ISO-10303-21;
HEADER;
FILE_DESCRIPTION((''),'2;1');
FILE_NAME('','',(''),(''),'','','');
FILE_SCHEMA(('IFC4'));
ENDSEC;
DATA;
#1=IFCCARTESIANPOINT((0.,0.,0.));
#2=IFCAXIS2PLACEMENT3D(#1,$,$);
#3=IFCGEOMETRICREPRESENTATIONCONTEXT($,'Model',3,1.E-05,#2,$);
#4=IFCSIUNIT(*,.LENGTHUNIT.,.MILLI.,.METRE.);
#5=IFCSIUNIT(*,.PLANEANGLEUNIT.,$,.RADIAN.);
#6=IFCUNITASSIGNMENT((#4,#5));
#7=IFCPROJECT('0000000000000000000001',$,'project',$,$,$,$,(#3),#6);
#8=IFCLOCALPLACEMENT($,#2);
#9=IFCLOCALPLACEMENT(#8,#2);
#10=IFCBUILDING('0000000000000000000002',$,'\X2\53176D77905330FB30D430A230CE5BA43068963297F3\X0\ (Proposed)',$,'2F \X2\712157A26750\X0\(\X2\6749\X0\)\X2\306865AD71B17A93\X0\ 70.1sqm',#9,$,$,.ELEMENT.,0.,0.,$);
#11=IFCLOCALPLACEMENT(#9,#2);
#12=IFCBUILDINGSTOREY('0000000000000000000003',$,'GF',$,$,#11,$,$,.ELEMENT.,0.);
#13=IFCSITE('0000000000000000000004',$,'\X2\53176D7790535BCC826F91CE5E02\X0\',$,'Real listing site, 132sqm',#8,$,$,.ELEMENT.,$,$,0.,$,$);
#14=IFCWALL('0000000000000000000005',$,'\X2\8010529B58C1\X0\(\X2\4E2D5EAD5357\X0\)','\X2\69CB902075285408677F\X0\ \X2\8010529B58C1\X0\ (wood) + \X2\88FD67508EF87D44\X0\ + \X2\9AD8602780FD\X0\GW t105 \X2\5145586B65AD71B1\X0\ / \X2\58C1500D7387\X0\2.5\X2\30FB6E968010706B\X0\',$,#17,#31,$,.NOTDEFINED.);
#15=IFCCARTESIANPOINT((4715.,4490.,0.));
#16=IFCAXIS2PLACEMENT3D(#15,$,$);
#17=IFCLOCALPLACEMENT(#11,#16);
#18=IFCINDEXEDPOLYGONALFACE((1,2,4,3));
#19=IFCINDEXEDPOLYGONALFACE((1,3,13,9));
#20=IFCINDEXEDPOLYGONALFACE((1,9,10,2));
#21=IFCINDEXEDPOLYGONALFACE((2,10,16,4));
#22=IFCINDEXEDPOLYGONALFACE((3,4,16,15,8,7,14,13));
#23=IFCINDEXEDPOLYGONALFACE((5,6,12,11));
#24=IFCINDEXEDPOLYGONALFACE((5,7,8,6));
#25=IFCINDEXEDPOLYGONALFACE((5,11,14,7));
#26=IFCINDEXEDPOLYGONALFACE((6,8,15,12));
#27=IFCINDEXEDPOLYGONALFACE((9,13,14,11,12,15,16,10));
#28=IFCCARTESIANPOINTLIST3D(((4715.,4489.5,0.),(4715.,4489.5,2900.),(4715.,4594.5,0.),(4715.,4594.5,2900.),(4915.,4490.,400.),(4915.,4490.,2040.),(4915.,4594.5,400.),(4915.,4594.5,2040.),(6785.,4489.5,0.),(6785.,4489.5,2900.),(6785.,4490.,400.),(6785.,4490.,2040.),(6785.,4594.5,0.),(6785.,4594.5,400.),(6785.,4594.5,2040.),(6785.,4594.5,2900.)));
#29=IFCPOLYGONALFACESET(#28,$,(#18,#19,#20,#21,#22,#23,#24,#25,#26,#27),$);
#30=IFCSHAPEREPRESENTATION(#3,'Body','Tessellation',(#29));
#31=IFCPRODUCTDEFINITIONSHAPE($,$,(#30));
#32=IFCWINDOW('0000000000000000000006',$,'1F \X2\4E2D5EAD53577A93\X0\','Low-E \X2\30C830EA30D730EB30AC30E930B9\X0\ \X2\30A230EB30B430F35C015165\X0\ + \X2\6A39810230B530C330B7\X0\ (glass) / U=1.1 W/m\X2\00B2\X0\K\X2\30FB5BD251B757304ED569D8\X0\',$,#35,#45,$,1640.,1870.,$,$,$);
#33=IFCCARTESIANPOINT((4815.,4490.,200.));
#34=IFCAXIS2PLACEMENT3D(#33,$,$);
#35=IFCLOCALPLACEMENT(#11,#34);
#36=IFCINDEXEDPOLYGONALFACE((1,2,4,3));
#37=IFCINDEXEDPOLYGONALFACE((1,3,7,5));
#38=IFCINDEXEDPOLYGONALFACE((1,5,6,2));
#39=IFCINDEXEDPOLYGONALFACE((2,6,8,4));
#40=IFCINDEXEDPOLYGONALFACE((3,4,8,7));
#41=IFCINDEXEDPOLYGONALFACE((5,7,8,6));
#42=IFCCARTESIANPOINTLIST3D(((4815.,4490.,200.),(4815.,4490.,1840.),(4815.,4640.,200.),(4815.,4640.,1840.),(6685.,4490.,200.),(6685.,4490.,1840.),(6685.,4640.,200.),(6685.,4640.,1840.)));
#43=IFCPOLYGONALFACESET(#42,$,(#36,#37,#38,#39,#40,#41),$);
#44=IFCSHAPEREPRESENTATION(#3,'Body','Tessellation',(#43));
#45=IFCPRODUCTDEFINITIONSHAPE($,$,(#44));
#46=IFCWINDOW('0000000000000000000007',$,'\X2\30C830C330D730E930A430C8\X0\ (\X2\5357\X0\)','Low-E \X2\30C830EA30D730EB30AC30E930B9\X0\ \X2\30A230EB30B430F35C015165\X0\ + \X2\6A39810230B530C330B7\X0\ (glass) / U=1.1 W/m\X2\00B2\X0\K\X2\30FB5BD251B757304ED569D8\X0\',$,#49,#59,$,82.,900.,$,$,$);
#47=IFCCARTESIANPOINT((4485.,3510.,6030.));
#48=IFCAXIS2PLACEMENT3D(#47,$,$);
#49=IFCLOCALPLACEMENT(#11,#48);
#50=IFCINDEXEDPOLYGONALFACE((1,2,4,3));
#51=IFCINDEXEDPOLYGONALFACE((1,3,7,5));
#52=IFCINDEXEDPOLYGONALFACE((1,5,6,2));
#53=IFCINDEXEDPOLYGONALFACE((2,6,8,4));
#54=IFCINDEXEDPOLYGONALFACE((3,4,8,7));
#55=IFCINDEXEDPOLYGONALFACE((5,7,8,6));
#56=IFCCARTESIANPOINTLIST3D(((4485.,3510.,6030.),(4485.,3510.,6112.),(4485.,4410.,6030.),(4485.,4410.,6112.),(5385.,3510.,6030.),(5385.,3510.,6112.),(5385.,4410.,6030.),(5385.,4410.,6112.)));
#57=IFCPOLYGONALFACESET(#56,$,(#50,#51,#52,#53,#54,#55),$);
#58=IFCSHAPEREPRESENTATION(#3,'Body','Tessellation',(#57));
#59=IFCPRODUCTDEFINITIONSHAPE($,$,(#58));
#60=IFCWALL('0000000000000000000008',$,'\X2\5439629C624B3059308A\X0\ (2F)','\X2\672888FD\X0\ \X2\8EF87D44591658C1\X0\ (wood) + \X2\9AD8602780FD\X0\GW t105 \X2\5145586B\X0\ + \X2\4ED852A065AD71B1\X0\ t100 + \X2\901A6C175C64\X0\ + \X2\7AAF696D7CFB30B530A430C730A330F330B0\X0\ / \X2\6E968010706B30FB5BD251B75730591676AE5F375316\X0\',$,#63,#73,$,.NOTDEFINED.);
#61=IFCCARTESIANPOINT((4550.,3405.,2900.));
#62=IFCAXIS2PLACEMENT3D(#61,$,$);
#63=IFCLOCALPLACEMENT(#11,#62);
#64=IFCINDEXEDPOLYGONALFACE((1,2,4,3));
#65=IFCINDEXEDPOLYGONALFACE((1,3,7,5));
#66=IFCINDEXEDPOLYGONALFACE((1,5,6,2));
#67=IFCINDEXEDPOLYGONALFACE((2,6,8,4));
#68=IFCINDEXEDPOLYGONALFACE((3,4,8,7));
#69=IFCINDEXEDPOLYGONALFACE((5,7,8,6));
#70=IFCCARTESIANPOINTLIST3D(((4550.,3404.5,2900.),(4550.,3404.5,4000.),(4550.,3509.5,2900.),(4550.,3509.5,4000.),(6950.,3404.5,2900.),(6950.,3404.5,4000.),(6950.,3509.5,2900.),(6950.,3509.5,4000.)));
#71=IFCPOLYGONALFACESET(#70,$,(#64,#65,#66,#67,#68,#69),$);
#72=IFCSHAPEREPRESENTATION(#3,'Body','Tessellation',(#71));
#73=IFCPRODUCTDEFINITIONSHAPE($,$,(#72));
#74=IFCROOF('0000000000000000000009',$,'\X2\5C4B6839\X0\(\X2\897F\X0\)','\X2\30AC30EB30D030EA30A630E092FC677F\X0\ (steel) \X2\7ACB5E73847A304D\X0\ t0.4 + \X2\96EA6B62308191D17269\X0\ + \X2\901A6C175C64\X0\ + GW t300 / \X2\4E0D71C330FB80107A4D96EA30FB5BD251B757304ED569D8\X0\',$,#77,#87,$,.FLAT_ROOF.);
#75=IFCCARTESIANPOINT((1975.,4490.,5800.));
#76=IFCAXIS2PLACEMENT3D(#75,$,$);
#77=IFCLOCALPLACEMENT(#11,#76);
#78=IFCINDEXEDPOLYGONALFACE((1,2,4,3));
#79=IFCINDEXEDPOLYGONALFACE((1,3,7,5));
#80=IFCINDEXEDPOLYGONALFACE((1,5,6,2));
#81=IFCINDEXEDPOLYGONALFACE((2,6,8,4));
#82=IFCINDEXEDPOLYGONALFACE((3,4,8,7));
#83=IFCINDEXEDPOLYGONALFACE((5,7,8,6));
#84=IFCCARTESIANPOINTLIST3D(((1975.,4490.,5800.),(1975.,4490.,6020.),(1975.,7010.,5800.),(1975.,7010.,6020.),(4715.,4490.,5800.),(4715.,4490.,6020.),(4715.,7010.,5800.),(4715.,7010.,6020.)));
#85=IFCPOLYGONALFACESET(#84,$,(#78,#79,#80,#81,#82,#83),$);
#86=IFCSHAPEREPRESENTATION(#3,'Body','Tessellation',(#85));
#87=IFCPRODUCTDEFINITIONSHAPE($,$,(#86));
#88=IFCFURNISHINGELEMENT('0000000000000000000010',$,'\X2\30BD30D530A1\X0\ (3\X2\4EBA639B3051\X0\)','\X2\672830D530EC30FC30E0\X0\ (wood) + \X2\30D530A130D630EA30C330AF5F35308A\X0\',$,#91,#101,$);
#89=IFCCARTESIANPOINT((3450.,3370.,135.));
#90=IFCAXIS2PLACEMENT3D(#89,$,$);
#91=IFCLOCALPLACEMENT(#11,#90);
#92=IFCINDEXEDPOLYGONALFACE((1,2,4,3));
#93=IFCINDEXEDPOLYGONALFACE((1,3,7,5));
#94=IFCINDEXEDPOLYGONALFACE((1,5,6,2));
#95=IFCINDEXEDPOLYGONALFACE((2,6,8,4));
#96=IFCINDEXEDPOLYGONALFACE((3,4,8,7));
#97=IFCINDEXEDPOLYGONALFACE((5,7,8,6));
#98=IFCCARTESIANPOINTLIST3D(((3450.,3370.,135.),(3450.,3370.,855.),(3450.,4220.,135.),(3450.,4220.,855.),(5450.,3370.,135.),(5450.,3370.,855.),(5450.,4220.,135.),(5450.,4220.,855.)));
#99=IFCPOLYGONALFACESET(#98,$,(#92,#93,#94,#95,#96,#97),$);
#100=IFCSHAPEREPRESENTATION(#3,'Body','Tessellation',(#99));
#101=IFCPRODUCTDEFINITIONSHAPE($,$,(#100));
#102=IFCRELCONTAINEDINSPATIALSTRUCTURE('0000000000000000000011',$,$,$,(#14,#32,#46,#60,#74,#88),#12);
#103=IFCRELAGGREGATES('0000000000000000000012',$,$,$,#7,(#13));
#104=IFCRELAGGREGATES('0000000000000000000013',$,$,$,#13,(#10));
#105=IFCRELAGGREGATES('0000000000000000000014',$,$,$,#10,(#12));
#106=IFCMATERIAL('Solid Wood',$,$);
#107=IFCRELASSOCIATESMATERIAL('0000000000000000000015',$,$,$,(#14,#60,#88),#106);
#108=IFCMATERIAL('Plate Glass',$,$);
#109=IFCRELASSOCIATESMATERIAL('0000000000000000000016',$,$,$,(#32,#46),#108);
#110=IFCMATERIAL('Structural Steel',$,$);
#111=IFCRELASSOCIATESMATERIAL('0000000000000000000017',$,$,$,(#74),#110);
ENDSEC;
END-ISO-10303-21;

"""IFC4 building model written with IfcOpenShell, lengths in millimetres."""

from ifc_helpers import new_model, si_unit, frame, frame_2d, origin, place, context, project, spatial, rectangle, extrude, material, element, fill, save


model = new_model("IFC4")

# Units and contexts
model_context = context("Model", 3, precision=1e-05, world=origin())
ifc_project = project(units=[si_unit("LENGTHUNIT", "METRE", prefix="MILLI"), si_unit("PLANEANGLEUNIT", "RADIAN")], contexts=[model_context])

# Site, building, storey
site_placement = place(None, origin())
site = spatial("IfcSite", under=ifc_project, at=site_placement, Name="北海道富良野市", ObjectType="Real listing site, 132sqm", CompositionType="ELEMENT", RefElevation=0.0)
building_placement = place(site_placement, origin())
building = spatial("IfcBuilding", under=site, at=building_placement, Name="北海道・ピアノ室と防音 (Proposed)", ObjectType="2F 無垢材(杉)と断熱窓 70.1sqm", CompositionType="ELEMENT", ElevationOfRefHeight=0.0, ElevationOfTerrain=0.0)
storey_placement = place(building_placement, origin())
storey = spatial("IfcBuildingStorey", under=building, at=storey_placement, Name="GF", CompositionType="ELEMENT", Elevation=0.0)

# Shared definitions
ifc_material_1 = material(Name="Solid Wood")

# Wall, opening, window
wall_1_placement = place(storey_placement, frame((4715.0, 4490.0, 0.0)))
wall_1 = element("IfcWall", 1, at=wall_1_placement, inside=storey, material=ifc_material_1, Name="耐力壁(中庭南)", Description="構造用合板 耐力壁 (wood) + 製材軸組 + 高性能GW t105 充填断熱 / 壁倍率2.5・準耐火", PredefinedType="NOTDEFINED", context=model_context, shape_type="SweptSolid", body=[
    extrude(rectangle(XDim=2070.0, YDim=105.0, at=frame_2d((1035.0, 52.0))), frame((4715.0, 4490.0, 0.0)), (0.0, 0.0, 1.0), 2900.0),
])
opening_placement = place(storey_placement, frame((4815.0, 4490.0, 200.0)))
opening = element("IfcOpeningElement", 2, at=opening_placement, cuts=wall_1, PredefinedType="NOTDEFINED", context=model_context, shape_type="SweptSolid", body=[
    extrude(rectangle(XDim=1870.0, YDim=150.0, at=frame_2d((935.0, 75.0))), frame((4815.0, 4490.0, 200.0)), (0.0, 0.0, 1.0), 1640.0),
])
ifc_material_2 = material(Name="Plate Glass")
window_1_placement = place(storey_placement, frame((4815.0, 4490.0, 200.0)))
window_1 = element("IfcWindow", 3, at=window_1_placement, inside=storey, material=ifc_material_2, Name="1F 中庭南窓", Description="Low-E トリプルガラス アルゴン封入 + 樹脂サッシ (glass) / U=1.1 W/m²K・寒冷地仕様", OverallHeight=1640.0, OverallWidth=1870.0, context=model_context, shape_type="SweptSolid", body=[
    extrude(rectangle(XDim=1870.0, YDim=150.0, at=frame_2d((935.0, 75.0))), frame((4815.0, 4490.0, 200.0)), (0.0, 0.0, 1.0), 1640.0),
])
fill(opening, window_1)

# Window
window_2_placement = place(storey_placement, frame((4485.0, 3510.0, 6030.0)))
element("IfcWindow", 4, at=window_2_placement, inside=storey, material=ifc_material_2, Name="トップライト (南)", Description="Low-E トリプルガラス アルゴン封入 + 樹脂サッシ (glass) / U=1.1 W/m²K・寒冷地仕様", OverallHeight=82.0, OverallWidth=900.0, context=model_context, shape_type="SweptSolid", body=[
    extrude(rectangle(XDim=900.0, YDim=900.0, at=frame_2d((450.0, 450.0))), frame((4485.0, 3510.0, 6030.0)), (0.0, 0.0, 1.0), 82.0),
])

# Wall
wall_2_placement = place(storey_placement, frame((4550.0, 3405.0, 2900.0)))
element("IfcWall", 5, at=wall_2_placement, inside=storey, material=ifc_material_1, Name="吹抜手すり (2F)", Description="木製 軸組外壁 (wood) + 高性能GW t105 充填 + 付加断熱 t100 + 通気層 + 窯業系サイディング / 準耐火・寒冷地外皮強化", PredefinedType="NOTDEFINED", context=model_context, shape_type="SweptSolid", body=[
    extrude(rectangle(XDim=2400.0, YDim=105.0, at=frame_2d((1200.0, 52.0))), frame((4550.0, 3405.0, 2900.0)), (0.0, 0.0, 1.0), 1100.0),
])

# Roof
ifc_material_3 = material(Name="Structural Steel")
for number, where, name in (
    (6, (1975.0, 4490.0, 5800.0), "屋根(西)"),
):
    element("IfcRoof", number, at=place(storey_placement, frame(where)), inside=storey, material=ifc_material_3, Name=name, Description="ガルバリウム鋼板 (steel) 立平葺き t0.4 + 雪止め金物 + 通気層 + GW t300 / 不燃・耐積雪・寒冷地仕様", PredefinedType="FLAT_ROOF", context=model_context, shape_type="SweptSolid", body=[
        extrude(rectangle(XDim=2740.0, YDim=2520.0, at=frame_2d((1370.0, 1260.0))), frame((1975.0, 4490.0, 5800.0)), (0.0, 0.0, 1.0), 220.0),
    ])

# Furnishing element
furnishing_placement = place(storey_placement, frame((3450.0, 3370.0, 135.0)))
element("IfcFurnishingElement", 7, at=furnishing_placement, inside=storey, material=ifc_material_1, Name="ソファ (3人掛け)", Description="木フレーム (wood) + ファブリック張り", context=model_context, shape_type="SweptSolid", body=[
    extrude(rectangle(XDim=2000.0, YDim=850.0, at=frame_2d((1000.0, 425.0))), frame((3450.0, 3370.0, 135.0)), (0.0, 0.0, 1.0), 720.0),
])

save(model, "model.ifc")
